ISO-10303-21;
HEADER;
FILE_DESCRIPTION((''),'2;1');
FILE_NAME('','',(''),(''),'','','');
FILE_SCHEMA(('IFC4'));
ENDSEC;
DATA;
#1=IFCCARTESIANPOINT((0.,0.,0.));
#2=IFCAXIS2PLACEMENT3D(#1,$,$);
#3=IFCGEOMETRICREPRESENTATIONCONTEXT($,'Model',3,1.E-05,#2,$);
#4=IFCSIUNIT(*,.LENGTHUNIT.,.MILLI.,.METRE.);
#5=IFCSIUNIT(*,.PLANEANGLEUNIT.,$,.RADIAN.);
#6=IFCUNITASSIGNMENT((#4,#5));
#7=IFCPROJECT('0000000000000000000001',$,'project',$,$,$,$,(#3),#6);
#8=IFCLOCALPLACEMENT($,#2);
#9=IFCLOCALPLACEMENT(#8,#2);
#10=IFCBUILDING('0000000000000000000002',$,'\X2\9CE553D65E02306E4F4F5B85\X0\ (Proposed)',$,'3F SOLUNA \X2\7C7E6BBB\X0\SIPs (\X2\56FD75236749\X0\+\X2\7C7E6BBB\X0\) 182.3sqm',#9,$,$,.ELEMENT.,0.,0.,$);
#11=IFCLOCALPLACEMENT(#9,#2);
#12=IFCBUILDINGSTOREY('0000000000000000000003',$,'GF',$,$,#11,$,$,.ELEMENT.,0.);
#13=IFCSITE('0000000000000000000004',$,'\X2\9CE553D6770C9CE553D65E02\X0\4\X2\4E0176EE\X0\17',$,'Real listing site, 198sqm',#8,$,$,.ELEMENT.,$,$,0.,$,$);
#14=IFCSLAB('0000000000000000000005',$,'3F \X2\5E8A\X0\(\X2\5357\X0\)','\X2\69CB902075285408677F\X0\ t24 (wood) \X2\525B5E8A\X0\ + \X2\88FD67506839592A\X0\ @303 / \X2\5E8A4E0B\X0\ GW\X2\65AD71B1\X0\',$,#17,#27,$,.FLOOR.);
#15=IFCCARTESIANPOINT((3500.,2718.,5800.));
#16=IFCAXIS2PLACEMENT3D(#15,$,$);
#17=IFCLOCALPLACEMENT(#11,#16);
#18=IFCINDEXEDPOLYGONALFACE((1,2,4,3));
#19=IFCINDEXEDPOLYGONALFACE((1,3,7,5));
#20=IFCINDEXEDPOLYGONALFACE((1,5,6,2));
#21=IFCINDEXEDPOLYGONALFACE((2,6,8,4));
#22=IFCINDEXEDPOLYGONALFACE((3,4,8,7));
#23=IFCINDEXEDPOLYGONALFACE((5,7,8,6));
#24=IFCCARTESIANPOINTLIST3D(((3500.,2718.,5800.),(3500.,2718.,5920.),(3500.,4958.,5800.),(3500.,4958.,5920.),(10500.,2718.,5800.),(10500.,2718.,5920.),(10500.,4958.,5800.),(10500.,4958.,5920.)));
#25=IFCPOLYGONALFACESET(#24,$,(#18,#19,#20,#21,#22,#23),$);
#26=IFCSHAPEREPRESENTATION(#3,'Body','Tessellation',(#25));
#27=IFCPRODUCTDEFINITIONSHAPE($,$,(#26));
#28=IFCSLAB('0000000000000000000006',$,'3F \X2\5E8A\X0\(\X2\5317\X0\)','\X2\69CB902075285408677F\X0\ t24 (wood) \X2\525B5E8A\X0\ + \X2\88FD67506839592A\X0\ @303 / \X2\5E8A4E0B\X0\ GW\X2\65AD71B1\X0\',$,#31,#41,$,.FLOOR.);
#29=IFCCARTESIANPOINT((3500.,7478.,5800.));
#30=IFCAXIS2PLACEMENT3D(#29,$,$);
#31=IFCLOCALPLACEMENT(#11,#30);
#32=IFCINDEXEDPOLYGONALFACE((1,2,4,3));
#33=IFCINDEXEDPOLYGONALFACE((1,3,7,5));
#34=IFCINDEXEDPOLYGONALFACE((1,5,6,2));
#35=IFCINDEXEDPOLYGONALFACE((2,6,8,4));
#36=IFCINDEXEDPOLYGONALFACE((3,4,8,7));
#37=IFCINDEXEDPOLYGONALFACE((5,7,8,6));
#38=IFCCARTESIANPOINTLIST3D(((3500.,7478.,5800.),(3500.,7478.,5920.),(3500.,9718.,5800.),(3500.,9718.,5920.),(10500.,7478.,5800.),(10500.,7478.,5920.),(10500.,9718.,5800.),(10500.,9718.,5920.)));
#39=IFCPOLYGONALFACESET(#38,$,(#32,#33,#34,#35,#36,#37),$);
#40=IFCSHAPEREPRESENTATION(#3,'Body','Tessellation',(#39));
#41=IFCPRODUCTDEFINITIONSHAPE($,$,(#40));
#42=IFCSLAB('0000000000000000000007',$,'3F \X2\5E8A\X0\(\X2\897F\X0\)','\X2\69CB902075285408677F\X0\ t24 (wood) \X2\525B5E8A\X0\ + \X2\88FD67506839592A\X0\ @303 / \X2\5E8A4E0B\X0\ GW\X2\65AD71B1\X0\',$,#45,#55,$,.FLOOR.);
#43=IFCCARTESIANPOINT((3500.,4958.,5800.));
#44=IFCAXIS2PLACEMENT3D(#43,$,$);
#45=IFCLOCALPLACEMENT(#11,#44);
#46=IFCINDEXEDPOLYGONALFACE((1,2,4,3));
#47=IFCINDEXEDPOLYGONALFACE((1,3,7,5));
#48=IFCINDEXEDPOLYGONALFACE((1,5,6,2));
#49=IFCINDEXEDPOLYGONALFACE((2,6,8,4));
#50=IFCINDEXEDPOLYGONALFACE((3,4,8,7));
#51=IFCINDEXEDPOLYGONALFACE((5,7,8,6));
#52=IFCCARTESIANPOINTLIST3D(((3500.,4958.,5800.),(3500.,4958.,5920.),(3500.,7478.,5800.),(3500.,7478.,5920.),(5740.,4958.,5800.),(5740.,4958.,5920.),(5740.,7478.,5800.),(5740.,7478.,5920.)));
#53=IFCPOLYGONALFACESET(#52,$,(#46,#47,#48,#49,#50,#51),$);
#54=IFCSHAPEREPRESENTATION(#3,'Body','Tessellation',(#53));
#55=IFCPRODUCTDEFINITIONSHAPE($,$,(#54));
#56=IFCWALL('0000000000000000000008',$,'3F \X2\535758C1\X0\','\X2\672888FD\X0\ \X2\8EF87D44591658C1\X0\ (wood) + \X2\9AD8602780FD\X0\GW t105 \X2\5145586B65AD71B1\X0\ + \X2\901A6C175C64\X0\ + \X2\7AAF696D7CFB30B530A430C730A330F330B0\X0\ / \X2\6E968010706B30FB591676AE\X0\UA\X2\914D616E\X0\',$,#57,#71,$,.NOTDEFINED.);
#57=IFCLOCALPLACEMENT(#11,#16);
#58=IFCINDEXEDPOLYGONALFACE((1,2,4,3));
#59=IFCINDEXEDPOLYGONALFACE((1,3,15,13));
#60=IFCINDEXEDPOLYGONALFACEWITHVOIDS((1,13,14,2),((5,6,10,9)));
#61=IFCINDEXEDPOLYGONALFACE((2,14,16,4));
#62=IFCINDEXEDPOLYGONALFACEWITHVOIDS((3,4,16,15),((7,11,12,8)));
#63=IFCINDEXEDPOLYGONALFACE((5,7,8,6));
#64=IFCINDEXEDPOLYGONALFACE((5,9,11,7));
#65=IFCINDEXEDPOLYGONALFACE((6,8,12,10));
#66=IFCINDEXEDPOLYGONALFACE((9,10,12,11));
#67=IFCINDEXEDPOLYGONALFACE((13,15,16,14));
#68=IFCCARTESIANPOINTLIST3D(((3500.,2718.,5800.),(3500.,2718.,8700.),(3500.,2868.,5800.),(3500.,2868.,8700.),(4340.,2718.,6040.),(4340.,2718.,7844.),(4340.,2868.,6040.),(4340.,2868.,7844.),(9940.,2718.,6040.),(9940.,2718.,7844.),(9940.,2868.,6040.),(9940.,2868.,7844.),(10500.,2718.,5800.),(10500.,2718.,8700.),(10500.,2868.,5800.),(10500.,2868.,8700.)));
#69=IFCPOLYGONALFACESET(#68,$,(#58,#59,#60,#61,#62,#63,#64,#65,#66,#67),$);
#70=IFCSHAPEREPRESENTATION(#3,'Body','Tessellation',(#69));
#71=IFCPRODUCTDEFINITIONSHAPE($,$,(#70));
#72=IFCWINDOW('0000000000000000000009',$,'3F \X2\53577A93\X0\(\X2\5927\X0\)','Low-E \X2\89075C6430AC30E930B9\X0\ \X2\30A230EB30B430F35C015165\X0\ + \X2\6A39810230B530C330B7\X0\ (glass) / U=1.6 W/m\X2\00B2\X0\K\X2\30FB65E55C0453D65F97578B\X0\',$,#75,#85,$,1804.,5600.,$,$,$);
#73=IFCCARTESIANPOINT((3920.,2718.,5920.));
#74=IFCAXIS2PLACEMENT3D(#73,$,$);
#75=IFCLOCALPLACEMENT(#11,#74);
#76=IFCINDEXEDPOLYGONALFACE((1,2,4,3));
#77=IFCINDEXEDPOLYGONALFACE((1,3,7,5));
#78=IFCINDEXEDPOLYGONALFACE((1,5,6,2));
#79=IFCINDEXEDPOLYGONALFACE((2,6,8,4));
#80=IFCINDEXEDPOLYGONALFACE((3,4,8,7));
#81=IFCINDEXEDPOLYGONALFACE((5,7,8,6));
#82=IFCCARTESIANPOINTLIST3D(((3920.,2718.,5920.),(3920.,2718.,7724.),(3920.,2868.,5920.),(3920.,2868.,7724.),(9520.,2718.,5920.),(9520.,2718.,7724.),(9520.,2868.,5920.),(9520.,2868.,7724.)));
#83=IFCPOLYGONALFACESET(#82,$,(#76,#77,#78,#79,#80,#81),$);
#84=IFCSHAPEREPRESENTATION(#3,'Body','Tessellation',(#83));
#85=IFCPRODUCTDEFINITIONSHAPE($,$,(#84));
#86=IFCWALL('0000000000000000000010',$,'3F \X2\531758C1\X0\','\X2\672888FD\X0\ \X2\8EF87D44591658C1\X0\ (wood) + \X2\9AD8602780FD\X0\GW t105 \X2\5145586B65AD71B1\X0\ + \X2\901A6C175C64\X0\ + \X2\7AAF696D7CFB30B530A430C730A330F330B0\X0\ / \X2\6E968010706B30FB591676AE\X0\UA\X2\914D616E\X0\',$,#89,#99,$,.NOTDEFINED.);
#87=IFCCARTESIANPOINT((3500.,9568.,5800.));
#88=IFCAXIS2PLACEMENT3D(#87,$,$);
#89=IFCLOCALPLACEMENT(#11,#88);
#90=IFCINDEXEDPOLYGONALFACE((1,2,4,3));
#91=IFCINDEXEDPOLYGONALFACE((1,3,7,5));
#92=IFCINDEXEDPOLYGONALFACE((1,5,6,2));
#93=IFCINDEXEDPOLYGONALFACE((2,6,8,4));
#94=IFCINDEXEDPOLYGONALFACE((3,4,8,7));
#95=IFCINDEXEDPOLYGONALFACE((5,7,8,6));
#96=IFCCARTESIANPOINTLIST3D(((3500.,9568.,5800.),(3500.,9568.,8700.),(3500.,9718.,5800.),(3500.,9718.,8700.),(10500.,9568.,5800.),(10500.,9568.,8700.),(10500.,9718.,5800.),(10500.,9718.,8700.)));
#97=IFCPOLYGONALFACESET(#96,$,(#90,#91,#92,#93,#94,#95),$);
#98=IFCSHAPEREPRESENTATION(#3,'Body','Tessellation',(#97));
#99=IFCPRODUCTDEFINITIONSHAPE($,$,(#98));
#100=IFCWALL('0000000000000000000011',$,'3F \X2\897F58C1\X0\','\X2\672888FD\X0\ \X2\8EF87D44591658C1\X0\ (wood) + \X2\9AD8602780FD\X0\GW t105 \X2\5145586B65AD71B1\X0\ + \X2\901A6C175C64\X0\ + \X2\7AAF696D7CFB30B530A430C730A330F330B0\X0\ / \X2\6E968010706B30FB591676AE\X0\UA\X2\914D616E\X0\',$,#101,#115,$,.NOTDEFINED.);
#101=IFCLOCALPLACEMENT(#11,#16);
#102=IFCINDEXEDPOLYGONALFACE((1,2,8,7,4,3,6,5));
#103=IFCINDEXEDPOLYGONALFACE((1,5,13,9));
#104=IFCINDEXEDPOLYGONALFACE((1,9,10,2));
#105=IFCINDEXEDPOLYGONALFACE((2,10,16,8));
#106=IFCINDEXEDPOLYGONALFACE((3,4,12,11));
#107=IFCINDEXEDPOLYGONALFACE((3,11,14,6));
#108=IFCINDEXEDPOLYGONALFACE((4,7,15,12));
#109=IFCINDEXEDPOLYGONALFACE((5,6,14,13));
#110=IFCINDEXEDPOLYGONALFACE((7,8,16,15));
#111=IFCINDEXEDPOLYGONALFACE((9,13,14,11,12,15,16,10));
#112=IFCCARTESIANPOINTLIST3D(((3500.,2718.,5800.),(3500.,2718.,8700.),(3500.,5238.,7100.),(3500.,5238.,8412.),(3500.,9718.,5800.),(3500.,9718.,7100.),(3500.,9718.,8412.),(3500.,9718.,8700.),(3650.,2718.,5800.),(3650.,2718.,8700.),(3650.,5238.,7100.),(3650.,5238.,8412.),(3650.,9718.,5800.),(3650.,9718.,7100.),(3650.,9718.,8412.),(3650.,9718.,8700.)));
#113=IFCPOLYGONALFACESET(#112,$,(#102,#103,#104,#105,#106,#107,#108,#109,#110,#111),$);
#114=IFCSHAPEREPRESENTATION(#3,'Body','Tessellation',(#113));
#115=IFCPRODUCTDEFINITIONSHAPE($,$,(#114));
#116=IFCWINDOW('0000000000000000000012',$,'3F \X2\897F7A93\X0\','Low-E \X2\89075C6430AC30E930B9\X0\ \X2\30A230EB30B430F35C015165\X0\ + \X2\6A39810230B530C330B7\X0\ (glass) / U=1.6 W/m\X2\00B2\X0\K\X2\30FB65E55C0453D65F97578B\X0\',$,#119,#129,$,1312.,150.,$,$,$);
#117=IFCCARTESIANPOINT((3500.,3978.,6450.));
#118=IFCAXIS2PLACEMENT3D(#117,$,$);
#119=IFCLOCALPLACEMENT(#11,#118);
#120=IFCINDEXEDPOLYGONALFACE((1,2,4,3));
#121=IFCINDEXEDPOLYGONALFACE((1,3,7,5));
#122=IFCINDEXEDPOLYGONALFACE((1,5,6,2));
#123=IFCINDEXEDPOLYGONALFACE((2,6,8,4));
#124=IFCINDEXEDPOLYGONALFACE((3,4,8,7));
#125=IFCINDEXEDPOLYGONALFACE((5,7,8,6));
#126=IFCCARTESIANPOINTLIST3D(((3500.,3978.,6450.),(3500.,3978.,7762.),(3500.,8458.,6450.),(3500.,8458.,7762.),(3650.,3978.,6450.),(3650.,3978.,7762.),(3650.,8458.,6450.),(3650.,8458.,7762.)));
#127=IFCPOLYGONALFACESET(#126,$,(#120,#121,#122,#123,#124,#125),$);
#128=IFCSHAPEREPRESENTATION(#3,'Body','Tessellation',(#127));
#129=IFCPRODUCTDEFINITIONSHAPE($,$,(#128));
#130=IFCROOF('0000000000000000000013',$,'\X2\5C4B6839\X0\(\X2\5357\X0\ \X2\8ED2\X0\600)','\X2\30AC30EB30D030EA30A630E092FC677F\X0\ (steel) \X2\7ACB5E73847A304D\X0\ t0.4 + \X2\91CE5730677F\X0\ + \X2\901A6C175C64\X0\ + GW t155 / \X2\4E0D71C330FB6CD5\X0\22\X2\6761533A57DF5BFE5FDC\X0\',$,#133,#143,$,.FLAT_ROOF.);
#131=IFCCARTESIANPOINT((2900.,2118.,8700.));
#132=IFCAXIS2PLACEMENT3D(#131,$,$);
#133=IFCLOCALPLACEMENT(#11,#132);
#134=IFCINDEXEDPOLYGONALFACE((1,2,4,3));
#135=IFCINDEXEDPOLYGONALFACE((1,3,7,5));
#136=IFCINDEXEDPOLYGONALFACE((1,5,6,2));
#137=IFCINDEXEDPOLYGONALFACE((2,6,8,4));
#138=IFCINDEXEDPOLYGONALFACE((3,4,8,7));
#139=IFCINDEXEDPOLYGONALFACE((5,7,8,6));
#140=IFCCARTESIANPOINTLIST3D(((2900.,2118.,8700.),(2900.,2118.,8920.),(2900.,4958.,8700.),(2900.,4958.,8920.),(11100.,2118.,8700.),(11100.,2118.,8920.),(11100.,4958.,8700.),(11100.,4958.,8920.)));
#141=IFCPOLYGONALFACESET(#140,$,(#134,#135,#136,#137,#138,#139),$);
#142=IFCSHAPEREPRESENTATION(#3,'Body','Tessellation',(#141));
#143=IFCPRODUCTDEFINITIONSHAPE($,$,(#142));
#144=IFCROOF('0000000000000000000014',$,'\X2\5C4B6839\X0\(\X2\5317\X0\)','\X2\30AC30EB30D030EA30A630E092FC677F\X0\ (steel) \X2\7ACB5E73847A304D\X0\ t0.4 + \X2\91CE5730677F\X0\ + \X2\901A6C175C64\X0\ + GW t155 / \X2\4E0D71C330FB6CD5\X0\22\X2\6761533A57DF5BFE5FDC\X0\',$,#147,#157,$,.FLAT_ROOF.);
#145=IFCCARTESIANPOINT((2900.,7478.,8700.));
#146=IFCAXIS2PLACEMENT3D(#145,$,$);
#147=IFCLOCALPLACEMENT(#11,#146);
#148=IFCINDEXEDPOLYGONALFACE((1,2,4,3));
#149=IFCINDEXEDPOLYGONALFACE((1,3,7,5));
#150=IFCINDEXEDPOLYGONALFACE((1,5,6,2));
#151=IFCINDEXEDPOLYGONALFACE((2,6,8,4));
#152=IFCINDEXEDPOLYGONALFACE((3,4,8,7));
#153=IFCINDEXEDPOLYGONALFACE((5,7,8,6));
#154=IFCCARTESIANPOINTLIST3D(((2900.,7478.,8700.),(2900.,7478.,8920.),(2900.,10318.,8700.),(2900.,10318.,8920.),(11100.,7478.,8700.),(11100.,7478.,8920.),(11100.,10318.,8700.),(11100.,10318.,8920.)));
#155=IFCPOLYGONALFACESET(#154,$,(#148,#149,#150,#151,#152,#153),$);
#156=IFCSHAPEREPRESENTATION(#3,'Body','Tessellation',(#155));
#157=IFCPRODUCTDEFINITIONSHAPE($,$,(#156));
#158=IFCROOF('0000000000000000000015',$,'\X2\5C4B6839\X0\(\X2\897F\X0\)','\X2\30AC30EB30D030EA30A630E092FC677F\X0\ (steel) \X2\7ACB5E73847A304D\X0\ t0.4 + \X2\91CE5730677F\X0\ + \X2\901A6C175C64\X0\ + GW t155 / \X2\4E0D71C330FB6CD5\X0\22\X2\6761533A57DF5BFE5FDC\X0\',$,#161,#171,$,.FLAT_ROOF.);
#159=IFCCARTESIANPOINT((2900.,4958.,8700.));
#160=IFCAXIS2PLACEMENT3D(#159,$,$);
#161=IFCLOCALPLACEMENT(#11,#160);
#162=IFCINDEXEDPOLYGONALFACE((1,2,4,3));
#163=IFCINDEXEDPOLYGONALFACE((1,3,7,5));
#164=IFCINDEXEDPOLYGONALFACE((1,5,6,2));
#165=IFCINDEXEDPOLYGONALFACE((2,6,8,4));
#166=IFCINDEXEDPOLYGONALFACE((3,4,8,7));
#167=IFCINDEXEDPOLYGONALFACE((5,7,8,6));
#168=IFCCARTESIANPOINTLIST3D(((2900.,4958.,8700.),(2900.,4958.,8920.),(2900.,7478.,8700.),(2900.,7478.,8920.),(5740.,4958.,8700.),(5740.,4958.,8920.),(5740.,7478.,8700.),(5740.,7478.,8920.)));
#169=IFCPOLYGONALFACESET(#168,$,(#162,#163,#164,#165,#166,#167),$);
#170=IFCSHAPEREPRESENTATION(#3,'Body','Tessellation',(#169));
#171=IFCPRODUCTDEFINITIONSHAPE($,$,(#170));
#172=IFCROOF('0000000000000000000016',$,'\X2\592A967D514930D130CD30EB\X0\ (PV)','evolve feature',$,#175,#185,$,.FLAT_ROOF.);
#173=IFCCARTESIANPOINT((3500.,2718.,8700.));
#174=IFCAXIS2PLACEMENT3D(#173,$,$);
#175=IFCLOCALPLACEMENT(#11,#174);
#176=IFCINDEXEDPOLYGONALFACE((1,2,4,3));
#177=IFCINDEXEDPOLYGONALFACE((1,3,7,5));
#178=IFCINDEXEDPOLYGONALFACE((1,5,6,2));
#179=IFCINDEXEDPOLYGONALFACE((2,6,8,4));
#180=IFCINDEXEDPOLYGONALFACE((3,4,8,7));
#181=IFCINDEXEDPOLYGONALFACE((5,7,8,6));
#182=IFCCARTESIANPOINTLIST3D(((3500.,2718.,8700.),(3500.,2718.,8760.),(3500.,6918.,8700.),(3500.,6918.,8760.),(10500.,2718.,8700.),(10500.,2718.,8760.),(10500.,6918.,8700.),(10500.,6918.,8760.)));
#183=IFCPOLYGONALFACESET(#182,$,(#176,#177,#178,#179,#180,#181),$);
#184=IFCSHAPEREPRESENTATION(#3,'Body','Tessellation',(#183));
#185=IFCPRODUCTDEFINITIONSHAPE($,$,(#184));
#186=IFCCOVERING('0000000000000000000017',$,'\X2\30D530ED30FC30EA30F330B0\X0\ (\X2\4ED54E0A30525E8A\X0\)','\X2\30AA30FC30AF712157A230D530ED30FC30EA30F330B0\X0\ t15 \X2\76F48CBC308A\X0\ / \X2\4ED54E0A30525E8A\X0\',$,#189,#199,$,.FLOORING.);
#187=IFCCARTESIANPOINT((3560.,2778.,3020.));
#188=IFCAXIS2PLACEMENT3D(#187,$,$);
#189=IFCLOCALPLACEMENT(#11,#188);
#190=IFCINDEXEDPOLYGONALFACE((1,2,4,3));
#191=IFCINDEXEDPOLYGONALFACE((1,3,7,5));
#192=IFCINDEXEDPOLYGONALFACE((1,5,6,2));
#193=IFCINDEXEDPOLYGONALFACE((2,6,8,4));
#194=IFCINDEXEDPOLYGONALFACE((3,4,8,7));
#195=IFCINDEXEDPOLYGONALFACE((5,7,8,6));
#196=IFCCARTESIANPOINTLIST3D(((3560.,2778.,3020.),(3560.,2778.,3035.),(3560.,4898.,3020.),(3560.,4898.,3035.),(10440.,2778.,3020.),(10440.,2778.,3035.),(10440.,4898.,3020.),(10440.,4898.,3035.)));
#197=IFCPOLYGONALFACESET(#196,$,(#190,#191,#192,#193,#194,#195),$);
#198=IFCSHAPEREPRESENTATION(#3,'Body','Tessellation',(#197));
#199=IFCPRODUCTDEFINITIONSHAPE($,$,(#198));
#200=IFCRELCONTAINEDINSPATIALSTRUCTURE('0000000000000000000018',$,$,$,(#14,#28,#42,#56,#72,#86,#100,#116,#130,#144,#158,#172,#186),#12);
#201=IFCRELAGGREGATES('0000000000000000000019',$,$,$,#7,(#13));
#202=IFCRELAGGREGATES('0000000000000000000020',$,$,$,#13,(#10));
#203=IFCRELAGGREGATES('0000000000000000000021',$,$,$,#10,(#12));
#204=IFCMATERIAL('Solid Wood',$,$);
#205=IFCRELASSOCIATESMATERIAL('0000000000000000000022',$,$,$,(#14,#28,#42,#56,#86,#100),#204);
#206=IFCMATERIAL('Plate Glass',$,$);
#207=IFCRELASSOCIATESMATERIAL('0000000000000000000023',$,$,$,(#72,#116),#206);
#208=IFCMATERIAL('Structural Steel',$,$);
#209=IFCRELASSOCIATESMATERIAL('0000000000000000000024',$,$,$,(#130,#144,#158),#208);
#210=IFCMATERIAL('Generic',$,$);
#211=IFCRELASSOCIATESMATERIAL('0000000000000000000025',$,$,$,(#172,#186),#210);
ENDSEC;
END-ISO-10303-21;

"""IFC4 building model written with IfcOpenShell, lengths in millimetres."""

from ifc_helpers import new_model, si_unit, frame, frame_2d, origin, place, context, project, spatial, rectangle, extrude, material, element, fill, save


model = new_model("IFC4")

# Units and contexts
model_context = context("Model", 3, precision=1e-05, world=origin())
ifc_project = project(units=[si_unit("LENGTHUNIT", "METRE", prefix="MILLI"), si_unit("PLANEANGLEUNIT", "RADIAN")], contexts=[model_context])

# Site, building, storey
site_placement = place(None, origin())
site = spatial("IfcSite", under=ifc_project, at=site_placement, Name="鳥取県鳥取市4丁目17", ObjectType="Real listing site, 198sqm", CompositionType="ELEMENT", RefElevation=0.0)
building_placement = place(site_placement, origin())
building = spatial("IfcBuilding", under=site, at=building_placement, Name="鳥取市の住宅 (Proposed)", ObjectType="3F SOLUNA 籾殻SIPs (国産杉+籾殻) 182.3sqm", CompositionType="ELEMENT", ElevationOfRefHeight=0.0, ElevationOfTerrain=0.0)
storey_placement = place(building_placement, origin())
storey = spatial("IfcBuildingStorey", under=building, at=storey_placement, Name="GF", CompositionType="ELEMENT", Elevation=0.0)

# Slabs
ifc_material_1 = material(Name="Solid Wood")
slab_1_placement = place(storey_placement, frame((3500.0, 2718.0, 5800.0)))
element("IfcSlab", 1, at=slab_1_placement, inside=storey, material=ifc_material_1, Name="3F 床(南)", Description="構造用合板 t24 (wood) 剛床 + 製材根太 @303 / 床下 GW断熱", PredefinedType="FLOOR", context=model_context, shape_type="SweptSolid", body=[
    extrude(rectangle(XDim=7000.0, YDim=2240.0, at=frame_2d((3500.0, 1120.0))), frame((3500.0, 2718.0, 5800.0)), (0.0, 0.0, 1.0), 120.0),
])
slab_2_placement = place(storey_placement, frame((3500.0, 7478.0, 5800.0)))
element("IfcSlab", 2, at=slab_2_placement, inside=storey, material=ifc_material_1, Name="3F 床(北)", Description="構造用合板 t24 (wood) 剛床 + 製材根太 @303 / 床下 GW断熱", PredefinedType="FLOOR", context=model_context, shape_type="SweptSolid", body=[
    extrude(rectangle(XDim=7000.0, YDim=2240.0, at=frame_2d((3500.0, 1120.0))), frame((3500.0, 7478.0, 5800.0)), (0.0, 0.0, 1.0), 120.0),
])
slab_3_placement = place(storey_placement, frame((3500.0, 4958.0, 5800.0)))
element("IfcSlab", 3, at=slab_3_placement, inside=storey, material=ifc_material_1, Name="3F 床(西)", Description="構造用合板 t24 (wood) 剛床 + 製材根太 @303 / 床下 GW断熱", PredefinedType="FLOOR", context=model_context, shape_type="SweptSolid", body=[
    extrude(rectangle(XDim=2240.0, YDim=2520.0, at=frame_2d((1120.0, 1260.0))), frame((3500.0, 4958.0, 5800.0)), (0.0, 0.0, 1.0), 120.0),
])

# Wall, opening, window
wall_1_placement = place(storey_placement, frame((3500.0, 2718.0, 5800.0)))
wall_1 = element("IfcWall", 4, at=wall_1_placement, inside=storey, material=ifc_material_1, Name="3F 南壁", Description="木製 軸組外壁 (wood) + 高性能GW t105 充填断熱 + 通気層 + 窯業系サイディング / 準耐火・外皮UA配慮", PredefinedType="NOTDEFINED", context=model_context, shape_type="SweptSolid", body=[
    extrude(rectangle(XDim=7000.0, YDim=150.0, at=frame_2d((3500.0, 75.0))), frame((3500.0, 2718.0, 5800.0)), (0.0, 0.0, 1.0), 2900.0),
])
opening_1_placement = place(storey_placement, frame((3920.0, 2718.0, 5920.0)))
opening_1 = element("IfcOpeningElement", 5, at=opening_1_placement, cuts=wall_1, PredefinedType="NOTDEFINED", context=model_context, shape_type="SweptSolid", body=[
    extrude(rectangle(XDim=5600.0, YDim=150.0, at=frame_2d((2800.0, 75.0))), frame((3920.0, 2718.0, 5920.0)), (0.0, 0.0, 1.0), 1804.0),
])
ifc_material_2 = material(Name="Plate Glass")
window_1_placement = place(storey_placement, frame((3920.0, 2718.0, 5920.0)))
window_1 = element("IfcWindow", 6, at=window_1_placement, inside=storey, material=ifc_material_2, Name="3F 南窓(大)", Description="Low-E 複層ガラス アルゴン封入 + 樹脂サッシ (glass) / U=1.6 W/m²K・日射取得型", OverallHeight=1804.0, OverallWidth=5600.0, context=model_context, shape_type="SweptSolid", body=[
    extrude(rectangle(XDim=5600.0, YDim=150.0, at=frame_2d((2800.0, 75.0))), frame((3920.0, 2718.0, 5920.0)), (0.0, 0.0, 1.0), 1804.0),
])
fill(opening_1, window_1)

# Wall
wall_2_placement = place(storey_placement, frame((3500.0, 9568.0, 5800.0)))
element("IfcWall", 7, at=wall_2_placement, inside=storey, material=ifc_material_1, Name="3F 北壁", Description="木製 軸組外壁 (wood) + 高性能GW t105 充填断熱 + 通気層 + 窯業系サイディング / 準耐火・外皮UA配慮", PredefinedType="NOTDEFINED", context=model_context, shape_type="SweptSolid", body=[
    extrude(rectangle(XDim=7000.0, YDim=150.0, at=frame_2d((3500.0, 75.0))), frame((3500.0, 9568.0, 5800.0)), (0.0, 0.0, 1.0), 2900.0),
])

# Wall, opening, window
wall_3_placement = place(storey_placement, frame((3500.0, 2718.0, 5800.0)))
wall_3 = element("IfcWall", 8, at=wall_3_placement, inside=storey, material=ifc_material_1, Name="3F 西壁", Description="木製 軸組外壁 (wood) + 高性能GW t105 充填断熱 + 通気層 + 窯業系サイディング / 準耐火・外皮UA配慮", PredefinedType="NOTDEFINED", context=model_context, shape_type="SweptSolid", body=[
    extrude(rectangle(XDim=150.0, YDim=7000.0, at=frame_2d((75.0, 3500.0))), frame((3500.0, 2718.0, 5800.0)), (0.0, 0.0, 1.0), 2900.0),
])
opening_2_placement = place(storey_placement, frame((3500.0, 3978.0, 6450.0)))
opening_2 = element("IfcOpeningElement", 9, at=opening_2_placement, cuts=wall_3, PredefinedType="NOTDEFINED", context=model_context, shape_type="SweptSolid", body=[
    extrude(rectangle(XDim=150.0, YDim=4480.0, at=frame_2d((75.0, 2240.0))), frame((3500.0, 3978.0, 6450.0)), (0.0, 0.0, 1.0), 1312.0),
])
window_2_placement = place(storey_placement, frame((3500.0, 3978.0, 6450.0)))
window_2 = element("IfcWindow", 10, at=window_2_placement, inside=storey, material=ifc_material_2, Name="3F 西窓", Description="Low-E 複層ガラス アルゴン封入 + 樹脂サッシ (glass) / U=1.6 W/m²K・日射取得型", OverallHeight=1312.0, OverallWidth=150.0, context=model_context, shape_type="SweptSolid", body=[
    extrude(rectangle(XDim=150.0, YDim=4480.0, at=frame_2d((75.0, 2240.0))), frame((3500.0, 3978.0, 6450.0)), (0.0, 0.0, 1.0), 1312.0),
])
fill(opening_2, window_2)

# Roofs
ifc_material_3 = material(Name="Structural Steel")
roof_1_placement = place(storey_placement, frame((2900.0, 2118.0, 8700.0)))
element("IfcRoof", 11, at=roof_1_placement, inside=storey, material=ifc_material_3, Name="屋根(南 軒600)", Description="ガルバリウム鋼板 (steel) 立平葺き t0.4 + 野地板 + 通気層 + GW t155 / 不燃・法22条区域対応", PredefinedType="FLAT_ROOF", context=model_context, shape_type="SweptSolid", body=[
    extrude(rectangle(XDim=8200.0, YDim=2840.0, at=frame_2d((4100.0, 1420.0))), frame((2900.0, 2118.0, 8700.0)), (0.0, 0.0, 1.0), 220.0),
])
roof_2_placement = place(storey_placement, frame((2900.0, 7478.0, 8700.0)))
element("IfcRoof", 12, at=roof_2_placement, inside=storey, material=ifc_material_3, Name="屋根(北)", Description="ガルバリウム鋼板 (steel) 立平葺き t0.4 + 野地板 + 通気層 + GW t155 / 不燃・法22条区域対応", PredefinedType="FLAT_ROOF", context=model_context, shape_type="SweptSolid", body=[
    extrude(rectangle(XDim=8200.0, YDim=2840.0, at=frame_2d((4100.0, 1420.0))), frame((2900.0, 7478.0, 8700.0)), (0.0, 0.0, 1.0), 220.0),
])
roof_3_placement = place(storey_placement, frame((2900.0, 4958.0, 8700.0)))
element("IfcRoof", 13, at=roof_3_placement, inside=storey, material=ifc_material_3, Name="屋根(西)", Description="ガルバリウム鋼板 (steel) 立平葺き t0.4 + 野地板 + 通気層 + GW t155 / 不燃・法22条区域対応", PredefinedType="FLAT_ROOF", context=model_context, shape_type="SweptSolid", body=[
    extrude(rectangle(XDim=2840.0, YDim=2520.0, at=frame_2d((1420.0, 1260.0))), frame((2900.0, 4958.0, 8700.0)), (0.0, 0.0, 1.0), 220.0),
])
ifc_material_4 = material(Name="Generic")
roof_4_placement = place(storey_placement, frame((3500.0, 2718.0, 8700.0)))
element("IfcRoof", 14, at=roof_4_placement, inside=storey, material=ifc_material_4, Name="太陽光パネル (PV)", Description="evolve feature", PredefinedType="FLAT_ROOF", context=model_context, shape_type="SweptSolid", body=[
    extrude(rectangle(XDim=7000.0, YDim=4200.0, at=frame_2d((3500.0, 2100.0))), frame((3500.0, 2718.0, 8700.0)), (0.0, 0.0, 1.0), 60.0),
])

# Covering
covering_1_placement = place(storey_placement, frame((3560.0, 2778.0, 3020.0)))
element("IfcCovering", 15, at=covering_1_placement, inside=storey, material=ifc_material_4, Name="フローリング (仕上げ床)", Description="オーク無垢フローリング t15 直貼り / 仕上げ床", PredefinedType="FLOORING", context=model_context, shape_type="SweptSolid", body=[
    extrude(rectangle(XDim=6880.0, YDim=2120.0, at=frame_2d((3440.0, 1060.0))), frame((3560.0, 2778.0, 3020.0)), (0.0, 0.0, 1.0), 15.0),
])

save(model, "model.ifc")
